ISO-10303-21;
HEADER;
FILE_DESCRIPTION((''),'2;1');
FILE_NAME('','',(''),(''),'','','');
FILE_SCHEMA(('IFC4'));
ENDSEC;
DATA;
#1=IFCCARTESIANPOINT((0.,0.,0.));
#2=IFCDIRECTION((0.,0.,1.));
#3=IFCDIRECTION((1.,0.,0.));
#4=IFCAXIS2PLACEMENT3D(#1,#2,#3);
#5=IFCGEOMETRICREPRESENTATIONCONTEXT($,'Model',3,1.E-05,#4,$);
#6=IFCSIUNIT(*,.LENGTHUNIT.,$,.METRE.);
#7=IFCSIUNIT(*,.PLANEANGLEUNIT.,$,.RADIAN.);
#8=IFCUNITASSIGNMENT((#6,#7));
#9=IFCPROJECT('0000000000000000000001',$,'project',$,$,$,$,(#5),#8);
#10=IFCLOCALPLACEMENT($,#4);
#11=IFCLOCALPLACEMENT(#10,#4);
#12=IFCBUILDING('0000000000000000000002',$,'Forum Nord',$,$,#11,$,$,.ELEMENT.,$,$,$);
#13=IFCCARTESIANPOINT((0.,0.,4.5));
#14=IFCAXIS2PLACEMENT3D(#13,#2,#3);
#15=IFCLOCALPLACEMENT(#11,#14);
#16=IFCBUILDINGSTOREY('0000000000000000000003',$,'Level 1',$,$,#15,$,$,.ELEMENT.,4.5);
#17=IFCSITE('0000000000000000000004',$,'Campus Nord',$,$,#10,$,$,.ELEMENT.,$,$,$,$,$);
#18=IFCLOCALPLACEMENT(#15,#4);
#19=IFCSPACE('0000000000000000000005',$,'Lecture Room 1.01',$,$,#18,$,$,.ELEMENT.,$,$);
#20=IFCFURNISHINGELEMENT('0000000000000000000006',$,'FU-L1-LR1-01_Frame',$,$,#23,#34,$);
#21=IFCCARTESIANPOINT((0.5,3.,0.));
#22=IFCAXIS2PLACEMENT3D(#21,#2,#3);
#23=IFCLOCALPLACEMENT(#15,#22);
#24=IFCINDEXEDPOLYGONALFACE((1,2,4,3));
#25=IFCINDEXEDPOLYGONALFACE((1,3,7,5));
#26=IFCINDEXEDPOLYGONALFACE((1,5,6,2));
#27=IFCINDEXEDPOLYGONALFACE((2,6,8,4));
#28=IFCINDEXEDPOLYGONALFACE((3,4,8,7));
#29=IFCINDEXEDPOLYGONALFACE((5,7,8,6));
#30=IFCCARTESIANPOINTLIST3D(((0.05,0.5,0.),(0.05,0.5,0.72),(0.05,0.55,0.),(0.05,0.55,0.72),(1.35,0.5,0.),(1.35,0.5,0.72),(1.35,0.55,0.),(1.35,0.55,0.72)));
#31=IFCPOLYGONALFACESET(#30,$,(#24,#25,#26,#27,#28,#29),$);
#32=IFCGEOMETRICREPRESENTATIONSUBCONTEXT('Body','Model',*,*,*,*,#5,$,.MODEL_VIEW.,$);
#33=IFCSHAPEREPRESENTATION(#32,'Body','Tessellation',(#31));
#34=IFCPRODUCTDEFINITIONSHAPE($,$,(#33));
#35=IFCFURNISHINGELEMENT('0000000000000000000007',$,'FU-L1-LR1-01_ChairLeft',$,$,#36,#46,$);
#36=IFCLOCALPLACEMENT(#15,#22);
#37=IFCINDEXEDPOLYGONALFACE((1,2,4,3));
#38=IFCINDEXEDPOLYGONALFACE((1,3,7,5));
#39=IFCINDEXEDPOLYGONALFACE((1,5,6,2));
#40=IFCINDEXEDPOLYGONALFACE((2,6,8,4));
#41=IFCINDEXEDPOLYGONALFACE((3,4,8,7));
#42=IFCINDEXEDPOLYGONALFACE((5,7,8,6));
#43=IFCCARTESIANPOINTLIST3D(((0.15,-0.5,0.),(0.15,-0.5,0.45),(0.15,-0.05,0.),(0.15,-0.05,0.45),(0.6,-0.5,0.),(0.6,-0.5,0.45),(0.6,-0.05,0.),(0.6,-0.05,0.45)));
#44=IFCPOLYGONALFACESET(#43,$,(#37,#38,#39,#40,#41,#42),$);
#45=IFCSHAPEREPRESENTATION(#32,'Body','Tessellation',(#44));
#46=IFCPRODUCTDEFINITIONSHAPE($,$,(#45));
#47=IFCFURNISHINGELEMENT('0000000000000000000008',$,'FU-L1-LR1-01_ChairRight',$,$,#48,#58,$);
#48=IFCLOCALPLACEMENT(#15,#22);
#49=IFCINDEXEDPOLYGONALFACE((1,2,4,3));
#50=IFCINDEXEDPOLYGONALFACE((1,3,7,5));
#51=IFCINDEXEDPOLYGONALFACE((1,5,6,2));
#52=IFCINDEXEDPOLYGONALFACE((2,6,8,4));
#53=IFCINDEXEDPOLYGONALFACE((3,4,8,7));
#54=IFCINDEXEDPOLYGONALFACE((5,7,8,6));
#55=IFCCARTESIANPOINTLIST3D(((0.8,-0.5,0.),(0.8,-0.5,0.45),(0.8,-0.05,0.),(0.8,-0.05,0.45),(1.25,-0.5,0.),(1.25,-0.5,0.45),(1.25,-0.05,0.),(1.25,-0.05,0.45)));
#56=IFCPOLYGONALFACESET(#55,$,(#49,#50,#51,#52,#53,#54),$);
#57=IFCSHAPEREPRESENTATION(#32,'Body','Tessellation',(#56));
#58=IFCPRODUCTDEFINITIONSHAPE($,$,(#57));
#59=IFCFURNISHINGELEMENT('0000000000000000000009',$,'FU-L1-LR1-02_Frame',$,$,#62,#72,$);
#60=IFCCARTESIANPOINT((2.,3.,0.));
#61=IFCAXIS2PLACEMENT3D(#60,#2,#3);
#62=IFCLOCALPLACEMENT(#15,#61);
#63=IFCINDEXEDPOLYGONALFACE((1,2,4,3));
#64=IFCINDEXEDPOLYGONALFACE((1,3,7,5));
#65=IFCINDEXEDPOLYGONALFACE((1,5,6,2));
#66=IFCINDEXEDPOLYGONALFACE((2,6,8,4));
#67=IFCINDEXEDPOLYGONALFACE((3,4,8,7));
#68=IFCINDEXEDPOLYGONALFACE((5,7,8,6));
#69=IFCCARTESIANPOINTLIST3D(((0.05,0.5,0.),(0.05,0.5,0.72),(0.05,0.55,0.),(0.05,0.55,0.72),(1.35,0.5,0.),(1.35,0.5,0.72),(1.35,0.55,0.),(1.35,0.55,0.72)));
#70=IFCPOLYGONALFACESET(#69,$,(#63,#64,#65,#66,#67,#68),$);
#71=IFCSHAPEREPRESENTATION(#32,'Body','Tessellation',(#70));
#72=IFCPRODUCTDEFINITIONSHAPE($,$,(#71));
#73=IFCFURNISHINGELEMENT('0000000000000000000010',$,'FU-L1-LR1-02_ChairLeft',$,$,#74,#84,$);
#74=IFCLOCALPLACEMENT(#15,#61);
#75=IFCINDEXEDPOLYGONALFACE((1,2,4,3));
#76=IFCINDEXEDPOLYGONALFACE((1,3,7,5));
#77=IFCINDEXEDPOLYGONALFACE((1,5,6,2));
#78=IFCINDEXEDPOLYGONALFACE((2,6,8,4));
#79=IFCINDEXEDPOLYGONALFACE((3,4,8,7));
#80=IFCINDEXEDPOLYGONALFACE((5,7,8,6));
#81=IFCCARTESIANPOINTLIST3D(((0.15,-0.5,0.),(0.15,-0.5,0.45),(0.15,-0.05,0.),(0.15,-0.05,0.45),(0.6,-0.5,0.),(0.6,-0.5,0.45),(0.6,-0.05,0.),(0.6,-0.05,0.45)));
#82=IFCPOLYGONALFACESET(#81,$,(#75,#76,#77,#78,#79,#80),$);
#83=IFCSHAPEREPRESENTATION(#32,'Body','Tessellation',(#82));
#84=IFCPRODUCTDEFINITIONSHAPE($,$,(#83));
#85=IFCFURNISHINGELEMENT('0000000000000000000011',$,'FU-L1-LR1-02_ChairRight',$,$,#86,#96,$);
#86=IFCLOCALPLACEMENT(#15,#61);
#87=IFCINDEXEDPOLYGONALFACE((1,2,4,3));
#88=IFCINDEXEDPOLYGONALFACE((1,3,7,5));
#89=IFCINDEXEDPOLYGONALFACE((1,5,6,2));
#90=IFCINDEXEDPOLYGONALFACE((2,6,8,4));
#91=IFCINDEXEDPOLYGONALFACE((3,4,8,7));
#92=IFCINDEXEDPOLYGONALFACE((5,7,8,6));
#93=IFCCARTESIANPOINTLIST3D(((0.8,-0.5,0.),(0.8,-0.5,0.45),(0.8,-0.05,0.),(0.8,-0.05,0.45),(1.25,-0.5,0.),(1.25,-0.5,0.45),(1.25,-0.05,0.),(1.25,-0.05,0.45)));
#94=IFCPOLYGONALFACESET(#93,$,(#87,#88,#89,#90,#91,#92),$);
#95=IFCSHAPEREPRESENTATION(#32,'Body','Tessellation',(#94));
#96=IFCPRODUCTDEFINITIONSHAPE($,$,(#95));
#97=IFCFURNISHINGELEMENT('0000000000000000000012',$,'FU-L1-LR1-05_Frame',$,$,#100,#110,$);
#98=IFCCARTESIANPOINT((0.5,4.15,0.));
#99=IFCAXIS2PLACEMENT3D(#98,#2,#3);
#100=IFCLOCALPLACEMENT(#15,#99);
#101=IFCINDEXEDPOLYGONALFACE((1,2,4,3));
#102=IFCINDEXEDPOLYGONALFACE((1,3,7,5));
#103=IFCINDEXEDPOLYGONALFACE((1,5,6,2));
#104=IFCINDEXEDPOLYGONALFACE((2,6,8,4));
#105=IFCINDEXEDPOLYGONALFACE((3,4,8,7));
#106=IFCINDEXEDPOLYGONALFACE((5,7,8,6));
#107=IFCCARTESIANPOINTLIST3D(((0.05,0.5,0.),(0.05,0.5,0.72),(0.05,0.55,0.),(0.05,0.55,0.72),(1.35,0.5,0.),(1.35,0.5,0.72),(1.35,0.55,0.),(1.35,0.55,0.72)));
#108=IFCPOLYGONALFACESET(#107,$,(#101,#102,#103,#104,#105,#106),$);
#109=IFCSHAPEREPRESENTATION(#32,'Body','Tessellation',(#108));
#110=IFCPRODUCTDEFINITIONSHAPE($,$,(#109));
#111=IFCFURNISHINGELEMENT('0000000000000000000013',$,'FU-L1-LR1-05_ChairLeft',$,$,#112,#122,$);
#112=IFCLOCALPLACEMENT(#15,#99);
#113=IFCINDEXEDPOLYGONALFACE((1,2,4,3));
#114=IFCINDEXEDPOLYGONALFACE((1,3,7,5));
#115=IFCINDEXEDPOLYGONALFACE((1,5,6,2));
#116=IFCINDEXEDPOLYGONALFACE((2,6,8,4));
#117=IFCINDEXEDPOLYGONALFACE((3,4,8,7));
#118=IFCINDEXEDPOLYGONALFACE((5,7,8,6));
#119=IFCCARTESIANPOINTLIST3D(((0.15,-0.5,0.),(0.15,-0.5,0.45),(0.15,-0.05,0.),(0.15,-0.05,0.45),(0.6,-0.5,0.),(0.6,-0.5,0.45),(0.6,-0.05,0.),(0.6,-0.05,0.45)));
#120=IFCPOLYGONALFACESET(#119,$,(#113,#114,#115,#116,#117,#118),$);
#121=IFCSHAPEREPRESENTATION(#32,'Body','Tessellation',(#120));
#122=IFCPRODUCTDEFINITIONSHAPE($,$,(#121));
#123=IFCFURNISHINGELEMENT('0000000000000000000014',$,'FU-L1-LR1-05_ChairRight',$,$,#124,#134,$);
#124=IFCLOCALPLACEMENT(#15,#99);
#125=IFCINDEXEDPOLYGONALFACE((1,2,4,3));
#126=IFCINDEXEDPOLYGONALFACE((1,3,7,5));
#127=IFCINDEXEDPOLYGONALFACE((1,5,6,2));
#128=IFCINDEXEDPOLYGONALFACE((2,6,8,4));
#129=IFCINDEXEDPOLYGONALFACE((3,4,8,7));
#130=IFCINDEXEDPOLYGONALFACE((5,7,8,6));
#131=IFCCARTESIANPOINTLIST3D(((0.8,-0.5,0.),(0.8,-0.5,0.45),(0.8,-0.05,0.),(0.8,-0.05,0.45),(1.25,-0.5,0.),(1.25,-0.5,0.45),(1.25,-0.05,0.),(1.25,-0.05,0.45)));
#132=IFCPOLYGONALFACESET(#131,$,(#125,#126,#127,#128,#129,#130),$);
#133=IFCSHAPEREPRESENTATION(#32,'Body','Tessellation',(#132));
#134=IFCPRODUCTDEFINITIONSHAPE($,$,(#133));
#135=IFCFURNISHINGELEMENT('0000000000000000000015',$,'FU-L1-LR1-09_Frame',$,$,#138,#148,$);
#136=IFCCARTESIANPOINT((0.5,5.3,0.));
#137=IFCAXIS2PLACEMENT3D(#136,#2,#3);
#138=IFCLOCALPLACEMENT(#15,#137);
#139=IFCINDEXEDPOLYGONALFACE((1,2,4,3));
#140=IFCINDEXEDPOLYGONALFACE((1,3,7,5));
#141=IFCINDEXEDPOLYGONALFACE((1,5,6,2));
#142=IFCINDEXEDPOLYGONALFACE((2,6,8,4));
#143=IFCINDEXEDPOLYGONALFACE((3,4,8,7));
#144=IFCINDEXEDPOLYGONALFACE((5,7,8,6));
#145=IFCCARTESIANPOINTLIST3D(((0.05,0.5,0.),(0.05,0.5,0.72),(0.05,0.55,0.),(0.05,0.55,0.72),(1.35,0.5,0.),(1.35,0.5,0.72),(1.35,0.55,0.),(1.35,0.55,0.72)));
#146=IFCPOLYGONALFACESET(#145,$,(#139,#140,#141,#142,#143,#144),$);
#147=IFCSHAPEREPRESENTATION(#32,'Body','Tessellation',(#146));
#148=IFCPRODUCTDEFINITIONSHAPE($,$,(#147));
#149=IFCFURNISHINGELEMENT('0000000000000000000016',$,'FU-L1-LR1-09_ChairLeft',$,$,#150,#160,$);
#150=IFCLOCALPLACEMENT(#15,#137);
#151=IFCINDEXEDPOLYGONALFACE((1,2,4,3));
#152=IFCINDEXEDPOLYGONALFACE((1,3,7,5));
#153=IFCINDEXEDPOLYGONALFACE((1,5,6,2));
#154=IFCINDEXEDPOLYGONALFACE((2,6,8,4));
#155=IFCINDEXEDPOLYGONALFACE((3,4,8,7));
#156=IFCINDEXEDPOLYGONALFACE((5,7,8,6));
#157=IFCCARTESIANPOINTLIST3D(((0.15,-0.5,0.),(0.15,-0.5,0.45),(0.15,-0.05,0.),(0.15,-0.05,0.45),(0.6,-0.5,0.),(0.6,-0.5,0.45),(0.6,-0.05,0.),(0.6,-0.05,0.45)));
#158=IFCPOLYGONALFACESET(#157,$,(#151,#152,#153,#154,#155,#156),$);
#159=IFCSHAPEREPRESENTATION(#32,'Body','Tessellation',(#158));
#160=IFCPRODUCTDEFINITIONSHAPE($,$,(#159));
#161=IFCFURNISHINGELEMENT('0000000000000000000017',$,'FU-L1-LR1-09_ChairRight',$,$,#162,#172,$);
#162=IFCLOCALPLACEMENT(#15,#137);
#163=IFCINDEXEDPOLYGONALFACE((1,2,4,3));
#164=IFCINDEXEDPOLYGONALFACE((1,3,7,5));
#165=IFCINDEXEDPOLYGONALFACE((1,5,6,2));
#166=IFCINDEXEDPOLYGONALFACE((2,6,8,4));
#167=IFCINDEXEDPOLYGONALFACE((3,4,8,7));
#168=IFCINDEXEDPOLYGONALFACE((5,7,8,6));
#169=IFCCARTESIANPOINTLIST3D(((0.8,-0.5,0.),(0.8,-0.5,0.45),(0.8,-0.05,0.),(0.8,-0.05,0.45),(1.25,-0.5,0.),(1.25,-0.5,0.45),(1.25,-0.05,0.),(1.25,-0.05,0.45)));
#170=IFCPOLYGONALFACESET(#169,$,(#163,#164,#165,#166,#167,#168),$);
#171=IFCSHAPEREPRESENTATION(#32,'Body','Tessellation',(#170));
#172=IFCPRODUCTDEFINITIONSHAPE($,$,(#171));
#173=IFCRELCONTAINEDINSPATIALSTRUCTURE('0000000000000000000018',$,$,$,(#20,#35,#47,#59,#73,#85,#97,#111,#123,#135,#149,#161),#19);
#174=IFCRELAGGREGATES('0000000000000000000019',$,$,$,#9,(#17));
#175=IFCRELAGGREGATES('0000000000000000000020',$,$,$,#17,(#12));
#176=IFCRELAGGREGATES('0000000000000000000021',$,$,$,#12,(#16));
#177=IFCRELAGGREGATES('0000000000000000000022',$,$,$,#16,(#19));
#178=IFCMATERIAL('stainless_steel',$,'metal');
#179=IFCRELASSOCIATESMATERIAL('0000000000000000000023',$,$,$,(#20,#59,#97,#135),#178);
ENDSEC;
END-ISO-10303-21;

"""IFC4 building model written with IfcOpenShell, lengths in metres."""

from ifc_helpers import new_model, si_unit, frame, frame_2d, origin_with_axes, place, context, subcontext, project, spatial, rectangle, extrude, material, element, save


model = new_model("IFC4")

# Units and contexts
model_context = context("Model", 3, precision=1e-05, world=origin_with_axes())
body_context = subcontext(model_context, "Body", "Model", "MODEL_VIEW")
ifc_project = project(units=[si_unit("LENGTHUNIT", "METRE"), si_unit("PLANEANGLEUNIT", "RADIAN")], contexts=[model_context])

# Site, building, storey
site_placement = place(None, origin_with_axes())
site = spatial("IfcSite", under=ifc_project, at=site_placement, Name="Campus Nord", CompositionType="ELEMENT")
building_placement = place(site_placement, origin_with_axes())
building = spatial("IfcBuilding", under=site, at=building_placement, Name="Forum Nord", CompositionType="ELEMENT")
storey_placement = place(building_placement, frame((0.0, 0.0, 4.5), z_axis=(0.0, 0.0, 1.0), x_axis=(1.0, 0.0, 0.0)))
storey = spatial("IfcBuildingStorey", under=building, at=storey_placement, Name="Level 1", CompositionType="ELEMENT", Elevation=4.5)

# Shared definitions
space_placement = place(storey_placement, origin_with_axes())
space = spatial("IfcSpace", under=storey, at=space_placement, Name="Lecture Room 1.01", CompositionType="ELEMENT")

# Furnishing elements
ifc_material_1 = material(Name="stainless_steel", Category="metal")
furnishing_1_placement = place(storey_placement, frame((0.5, 3.0, 0.0), z_axis=(0.0, 0.0, 1.0), x_axis=(1.0, 0.0, 0.0)))
element("IfcFurnishingElement", 1, at=furnishing_1_placement, inside=space, material=ifc_material_1, Name="FU-L1-LR1-01_Frame", context=body_context, shape_type="SweptSolid", body=[
    extrude(rectangle(XDim=1.3, YDim=0.05, at=frame_2d((0.7, 0.525), x_axis=(1.0, 0.0))), origin_with_axes(), (0.0, 0.0, 1.0), 0.72),
])
furnishing_2_placement = place(storey_placement, frame((0.5, 3.0, 0.0), z_axis=(0.0, 0.0, 1.0), x_axis=(1.0, 0.0, 0.0)))
element("IfcFurnishingElement", 2, at=furnishing_2_placement, inside=space, Name="FU-L1-LR1-01_ChairLeft", context=body_context, shape_type="SweptSolid", body=[
    extrude(rectangle(XDim=0.45, YDim=0.45, at=frame_2d((0.375, -0.275), x_axis=(1.0, 0.0))), origin_with_axes(), (0.0, 0.0, 1.0), 0.45),
])
furnishing_3_placement = place(storey_placement, frame((0.5, 3.0, 0.0), z_axis=(0.0, 0.0, 1.0), x_axis=(1.0, 0.0, 0.0)))
element("IfcFurnishingElement", 3, at=furnishing_3_placement, inside=space, Name="FU-L1-LR1-01_ChairRight", context=body_context, shape_type="SweptSolid", body=[
    extrude(rectangle(XDim=0.45, YDim=0.45, at=frame_2d((1.025, -0.275), x_axis=(1.0, 0.0))), origin_with_axes(), (0.0, 0.0, 1.0), 0.45),
])
furnishing_4_placement = place(storey_placement, frame((2.0, 3.0, 0.0), z_axis=(0.0, 0.0, 1.0), x_axis=(1.0, 0.0, 0.0)))
element("IfcFurnishingElement", 4, at=furnishing_4_placement, inside=space, material=ifc_material_1, Name="FU-L1-LR1-02_Frame", context=body_context, shape_type="SweptSolid", body=[
    extrude(rectangle(XDim=1.3, YDim=0.05, at=frame_2d((0.7, 0.525), x_axis=(1.0, 0.0))), origin_with_axes(), (0.0, 0.0, 1.0), 0.72),
])
furnishing_5_placement = place(storey_placement, frame((2.0, 3.0, 0.0), z_axis=(0.0, 0.0, 1.0), x_axis=(1.0, 0.0, 0.0)))
element("IfcFurnishingElement", 5, at=furnishing_5_placement, inside=space, Name="FU-L1-LR1-02_ChairLeft", context=body_context, shape_type="SweptSolid", body=[
    extrude(rectangle(XDim=0.45, YDim=0.45, at=frame_2d((0.375, -0.275), x_axis=(1.0, 0.0))), origin_with_axes(), (0.0, 0.0, 1.0), 0.45),
])
furnishing_6_placement = place(storey_placement, frame((2.0, 3.0, 0.0), z_axis=(0.0, 0.0, 1.0), x_axis=(1.0, 0.0, 0.0)))
element("IfcFurnishingElement", 6, at=furnishing_6_placement, inside=space, Name="FU-L1-LR1-02_ChairRight", context=body_context, shape_type="SweptSolid", body=[
    extrude(rectangle(XDim=0.45, YDim=0.45, at=frame_2d((1.025, -0.275), x_axis=(1.0, 0.0))), origin_with_axes(), (0.0, 0.0, 1.0), 0.45),
])
furnishing_7_placement = place(storey_placement, frame((0.5, 4.15, 0.0), z_axis=(0.0, 0.0, 1.0), x_axis=(1.0, 0.0, 0.0)))
element("IfcFurnishingElement", 7, at=furnishing_7_placement, inside=space, material=ifc_material_1, Name="FU-L1-LR1-05_Frame", context=body_context, shape_type="SweptSolid", body=[
    extrude(rectangle(XDim=1.3, YDim=0.05, at=frame_2d((0.7, 0.525), x_axis=(1.0, 0.0))), origin_with_axes(), (0.0, 0.0, 1.0), 0.72),
])
furnishing_8_placement = place(storey_placement, frame((0.5, 4.15, 0.0), z_axis=(0.0, 0.0, 1.0), x_axis=(1.0, 0.0, 0.0)))
element("IfcFurnishingElement", 8, at=furnishing_8_placement, inside=space, Name="FU-L1-LR1-05_ChairLeft", context=body_context, shape_type="SweptSolid", body=[
    extrude(rectangle(XDim=0.45, YDim=0.45, at=frame_2d((0.375, -0.275), x_axis=(1.0, 0.0))), origin_with_axes(), (0.0, 0.0, 1.0), 0.45),
])
furnishing_9_placement = place(storey_placement, frame((0.5, 4.15, 0.0), z_axis=(0.0, 0.0, 1.0), x_axis=(1.0, 0.0, 0.0)))
element("IfcFurnishingElement", 9, at=furnishing_9_placement, inside=space, Name="FU-L1-LR1-05_ChairRight", context=body_context, shape_type="SweptSolid", body=[
    extrude(rectangle(XDim=0.45, YDim=0.45, at=frame_2d((1.025, -0.275), x_axis=(1.0, 0.0))), origin_with_axes(), (0.0, 0.0, 1.0), 0.45),
])
furnishing_10_placement = place(storey_placement, frame((0.5, 5.3, 0.0), z_axis=(0.0, 0.0, 1.0), x_axis=(1.0, 0.0, 0.0)))
element("IfcFurnishingElement", 10, at=furnishing_10_placement, inside=space, material=ifc_material_1, Name="FU-L1-LR1-09_Frame", context=body_context, shape_type="SweptSolid", body=[
    extrude(rectangle(XDim=1.3, YDim=0.05, at=frame_2d((0.7, 0.525), x_axis=(1.0, 0.0))), origin_with_axes(), (0.0, 0.0, 1.0), 0.72),
])
furnishing_11_placement = place(storey_placement, frame((0.5, 5.3, 0.0), z_axis=(0.0, 0.0, 1.0), x_axis=(1.0, 0.0, 0.0)))
element("IfcFurnishingElement", 11, at=furnishing_11_placement, inside=space, Name="FU-L1-LR1-09_ChairLeft", context=body_context, shape_type="SweptSolid", body=[
    extrude(rectangle(XDim=0.45, YDim=0.45, at=frame_2d((0.375, -0.275), x_axis=(1.0, 0.0))), origin_with_axes(), (0.0, 0.0, 1.0), 0.45),
])
furnishing_12_placement = place(storey_placement, frame((0.5, 5.3, 0.0), z_axis=(0.0, 0.0, 1.0), x_axis=(1.0, 0.0, 0.0)))
element("IfcFurnishingElement", 12, at=furnishing_12_placement, inside=space, Name="FU-L1-LR1-09_ChairRight", context=body_context, shape_type="SweptSolid", body=[
    extrude(rectangle(XDim=0.45, YDim=0.45, at=frame_2d((1.025, -0.275), x_axis=(1.0, 0.0))), origin_with_axes(), (0.0, 0.0, 1.0), 0.45),
])

save(model, "model.ifc")
